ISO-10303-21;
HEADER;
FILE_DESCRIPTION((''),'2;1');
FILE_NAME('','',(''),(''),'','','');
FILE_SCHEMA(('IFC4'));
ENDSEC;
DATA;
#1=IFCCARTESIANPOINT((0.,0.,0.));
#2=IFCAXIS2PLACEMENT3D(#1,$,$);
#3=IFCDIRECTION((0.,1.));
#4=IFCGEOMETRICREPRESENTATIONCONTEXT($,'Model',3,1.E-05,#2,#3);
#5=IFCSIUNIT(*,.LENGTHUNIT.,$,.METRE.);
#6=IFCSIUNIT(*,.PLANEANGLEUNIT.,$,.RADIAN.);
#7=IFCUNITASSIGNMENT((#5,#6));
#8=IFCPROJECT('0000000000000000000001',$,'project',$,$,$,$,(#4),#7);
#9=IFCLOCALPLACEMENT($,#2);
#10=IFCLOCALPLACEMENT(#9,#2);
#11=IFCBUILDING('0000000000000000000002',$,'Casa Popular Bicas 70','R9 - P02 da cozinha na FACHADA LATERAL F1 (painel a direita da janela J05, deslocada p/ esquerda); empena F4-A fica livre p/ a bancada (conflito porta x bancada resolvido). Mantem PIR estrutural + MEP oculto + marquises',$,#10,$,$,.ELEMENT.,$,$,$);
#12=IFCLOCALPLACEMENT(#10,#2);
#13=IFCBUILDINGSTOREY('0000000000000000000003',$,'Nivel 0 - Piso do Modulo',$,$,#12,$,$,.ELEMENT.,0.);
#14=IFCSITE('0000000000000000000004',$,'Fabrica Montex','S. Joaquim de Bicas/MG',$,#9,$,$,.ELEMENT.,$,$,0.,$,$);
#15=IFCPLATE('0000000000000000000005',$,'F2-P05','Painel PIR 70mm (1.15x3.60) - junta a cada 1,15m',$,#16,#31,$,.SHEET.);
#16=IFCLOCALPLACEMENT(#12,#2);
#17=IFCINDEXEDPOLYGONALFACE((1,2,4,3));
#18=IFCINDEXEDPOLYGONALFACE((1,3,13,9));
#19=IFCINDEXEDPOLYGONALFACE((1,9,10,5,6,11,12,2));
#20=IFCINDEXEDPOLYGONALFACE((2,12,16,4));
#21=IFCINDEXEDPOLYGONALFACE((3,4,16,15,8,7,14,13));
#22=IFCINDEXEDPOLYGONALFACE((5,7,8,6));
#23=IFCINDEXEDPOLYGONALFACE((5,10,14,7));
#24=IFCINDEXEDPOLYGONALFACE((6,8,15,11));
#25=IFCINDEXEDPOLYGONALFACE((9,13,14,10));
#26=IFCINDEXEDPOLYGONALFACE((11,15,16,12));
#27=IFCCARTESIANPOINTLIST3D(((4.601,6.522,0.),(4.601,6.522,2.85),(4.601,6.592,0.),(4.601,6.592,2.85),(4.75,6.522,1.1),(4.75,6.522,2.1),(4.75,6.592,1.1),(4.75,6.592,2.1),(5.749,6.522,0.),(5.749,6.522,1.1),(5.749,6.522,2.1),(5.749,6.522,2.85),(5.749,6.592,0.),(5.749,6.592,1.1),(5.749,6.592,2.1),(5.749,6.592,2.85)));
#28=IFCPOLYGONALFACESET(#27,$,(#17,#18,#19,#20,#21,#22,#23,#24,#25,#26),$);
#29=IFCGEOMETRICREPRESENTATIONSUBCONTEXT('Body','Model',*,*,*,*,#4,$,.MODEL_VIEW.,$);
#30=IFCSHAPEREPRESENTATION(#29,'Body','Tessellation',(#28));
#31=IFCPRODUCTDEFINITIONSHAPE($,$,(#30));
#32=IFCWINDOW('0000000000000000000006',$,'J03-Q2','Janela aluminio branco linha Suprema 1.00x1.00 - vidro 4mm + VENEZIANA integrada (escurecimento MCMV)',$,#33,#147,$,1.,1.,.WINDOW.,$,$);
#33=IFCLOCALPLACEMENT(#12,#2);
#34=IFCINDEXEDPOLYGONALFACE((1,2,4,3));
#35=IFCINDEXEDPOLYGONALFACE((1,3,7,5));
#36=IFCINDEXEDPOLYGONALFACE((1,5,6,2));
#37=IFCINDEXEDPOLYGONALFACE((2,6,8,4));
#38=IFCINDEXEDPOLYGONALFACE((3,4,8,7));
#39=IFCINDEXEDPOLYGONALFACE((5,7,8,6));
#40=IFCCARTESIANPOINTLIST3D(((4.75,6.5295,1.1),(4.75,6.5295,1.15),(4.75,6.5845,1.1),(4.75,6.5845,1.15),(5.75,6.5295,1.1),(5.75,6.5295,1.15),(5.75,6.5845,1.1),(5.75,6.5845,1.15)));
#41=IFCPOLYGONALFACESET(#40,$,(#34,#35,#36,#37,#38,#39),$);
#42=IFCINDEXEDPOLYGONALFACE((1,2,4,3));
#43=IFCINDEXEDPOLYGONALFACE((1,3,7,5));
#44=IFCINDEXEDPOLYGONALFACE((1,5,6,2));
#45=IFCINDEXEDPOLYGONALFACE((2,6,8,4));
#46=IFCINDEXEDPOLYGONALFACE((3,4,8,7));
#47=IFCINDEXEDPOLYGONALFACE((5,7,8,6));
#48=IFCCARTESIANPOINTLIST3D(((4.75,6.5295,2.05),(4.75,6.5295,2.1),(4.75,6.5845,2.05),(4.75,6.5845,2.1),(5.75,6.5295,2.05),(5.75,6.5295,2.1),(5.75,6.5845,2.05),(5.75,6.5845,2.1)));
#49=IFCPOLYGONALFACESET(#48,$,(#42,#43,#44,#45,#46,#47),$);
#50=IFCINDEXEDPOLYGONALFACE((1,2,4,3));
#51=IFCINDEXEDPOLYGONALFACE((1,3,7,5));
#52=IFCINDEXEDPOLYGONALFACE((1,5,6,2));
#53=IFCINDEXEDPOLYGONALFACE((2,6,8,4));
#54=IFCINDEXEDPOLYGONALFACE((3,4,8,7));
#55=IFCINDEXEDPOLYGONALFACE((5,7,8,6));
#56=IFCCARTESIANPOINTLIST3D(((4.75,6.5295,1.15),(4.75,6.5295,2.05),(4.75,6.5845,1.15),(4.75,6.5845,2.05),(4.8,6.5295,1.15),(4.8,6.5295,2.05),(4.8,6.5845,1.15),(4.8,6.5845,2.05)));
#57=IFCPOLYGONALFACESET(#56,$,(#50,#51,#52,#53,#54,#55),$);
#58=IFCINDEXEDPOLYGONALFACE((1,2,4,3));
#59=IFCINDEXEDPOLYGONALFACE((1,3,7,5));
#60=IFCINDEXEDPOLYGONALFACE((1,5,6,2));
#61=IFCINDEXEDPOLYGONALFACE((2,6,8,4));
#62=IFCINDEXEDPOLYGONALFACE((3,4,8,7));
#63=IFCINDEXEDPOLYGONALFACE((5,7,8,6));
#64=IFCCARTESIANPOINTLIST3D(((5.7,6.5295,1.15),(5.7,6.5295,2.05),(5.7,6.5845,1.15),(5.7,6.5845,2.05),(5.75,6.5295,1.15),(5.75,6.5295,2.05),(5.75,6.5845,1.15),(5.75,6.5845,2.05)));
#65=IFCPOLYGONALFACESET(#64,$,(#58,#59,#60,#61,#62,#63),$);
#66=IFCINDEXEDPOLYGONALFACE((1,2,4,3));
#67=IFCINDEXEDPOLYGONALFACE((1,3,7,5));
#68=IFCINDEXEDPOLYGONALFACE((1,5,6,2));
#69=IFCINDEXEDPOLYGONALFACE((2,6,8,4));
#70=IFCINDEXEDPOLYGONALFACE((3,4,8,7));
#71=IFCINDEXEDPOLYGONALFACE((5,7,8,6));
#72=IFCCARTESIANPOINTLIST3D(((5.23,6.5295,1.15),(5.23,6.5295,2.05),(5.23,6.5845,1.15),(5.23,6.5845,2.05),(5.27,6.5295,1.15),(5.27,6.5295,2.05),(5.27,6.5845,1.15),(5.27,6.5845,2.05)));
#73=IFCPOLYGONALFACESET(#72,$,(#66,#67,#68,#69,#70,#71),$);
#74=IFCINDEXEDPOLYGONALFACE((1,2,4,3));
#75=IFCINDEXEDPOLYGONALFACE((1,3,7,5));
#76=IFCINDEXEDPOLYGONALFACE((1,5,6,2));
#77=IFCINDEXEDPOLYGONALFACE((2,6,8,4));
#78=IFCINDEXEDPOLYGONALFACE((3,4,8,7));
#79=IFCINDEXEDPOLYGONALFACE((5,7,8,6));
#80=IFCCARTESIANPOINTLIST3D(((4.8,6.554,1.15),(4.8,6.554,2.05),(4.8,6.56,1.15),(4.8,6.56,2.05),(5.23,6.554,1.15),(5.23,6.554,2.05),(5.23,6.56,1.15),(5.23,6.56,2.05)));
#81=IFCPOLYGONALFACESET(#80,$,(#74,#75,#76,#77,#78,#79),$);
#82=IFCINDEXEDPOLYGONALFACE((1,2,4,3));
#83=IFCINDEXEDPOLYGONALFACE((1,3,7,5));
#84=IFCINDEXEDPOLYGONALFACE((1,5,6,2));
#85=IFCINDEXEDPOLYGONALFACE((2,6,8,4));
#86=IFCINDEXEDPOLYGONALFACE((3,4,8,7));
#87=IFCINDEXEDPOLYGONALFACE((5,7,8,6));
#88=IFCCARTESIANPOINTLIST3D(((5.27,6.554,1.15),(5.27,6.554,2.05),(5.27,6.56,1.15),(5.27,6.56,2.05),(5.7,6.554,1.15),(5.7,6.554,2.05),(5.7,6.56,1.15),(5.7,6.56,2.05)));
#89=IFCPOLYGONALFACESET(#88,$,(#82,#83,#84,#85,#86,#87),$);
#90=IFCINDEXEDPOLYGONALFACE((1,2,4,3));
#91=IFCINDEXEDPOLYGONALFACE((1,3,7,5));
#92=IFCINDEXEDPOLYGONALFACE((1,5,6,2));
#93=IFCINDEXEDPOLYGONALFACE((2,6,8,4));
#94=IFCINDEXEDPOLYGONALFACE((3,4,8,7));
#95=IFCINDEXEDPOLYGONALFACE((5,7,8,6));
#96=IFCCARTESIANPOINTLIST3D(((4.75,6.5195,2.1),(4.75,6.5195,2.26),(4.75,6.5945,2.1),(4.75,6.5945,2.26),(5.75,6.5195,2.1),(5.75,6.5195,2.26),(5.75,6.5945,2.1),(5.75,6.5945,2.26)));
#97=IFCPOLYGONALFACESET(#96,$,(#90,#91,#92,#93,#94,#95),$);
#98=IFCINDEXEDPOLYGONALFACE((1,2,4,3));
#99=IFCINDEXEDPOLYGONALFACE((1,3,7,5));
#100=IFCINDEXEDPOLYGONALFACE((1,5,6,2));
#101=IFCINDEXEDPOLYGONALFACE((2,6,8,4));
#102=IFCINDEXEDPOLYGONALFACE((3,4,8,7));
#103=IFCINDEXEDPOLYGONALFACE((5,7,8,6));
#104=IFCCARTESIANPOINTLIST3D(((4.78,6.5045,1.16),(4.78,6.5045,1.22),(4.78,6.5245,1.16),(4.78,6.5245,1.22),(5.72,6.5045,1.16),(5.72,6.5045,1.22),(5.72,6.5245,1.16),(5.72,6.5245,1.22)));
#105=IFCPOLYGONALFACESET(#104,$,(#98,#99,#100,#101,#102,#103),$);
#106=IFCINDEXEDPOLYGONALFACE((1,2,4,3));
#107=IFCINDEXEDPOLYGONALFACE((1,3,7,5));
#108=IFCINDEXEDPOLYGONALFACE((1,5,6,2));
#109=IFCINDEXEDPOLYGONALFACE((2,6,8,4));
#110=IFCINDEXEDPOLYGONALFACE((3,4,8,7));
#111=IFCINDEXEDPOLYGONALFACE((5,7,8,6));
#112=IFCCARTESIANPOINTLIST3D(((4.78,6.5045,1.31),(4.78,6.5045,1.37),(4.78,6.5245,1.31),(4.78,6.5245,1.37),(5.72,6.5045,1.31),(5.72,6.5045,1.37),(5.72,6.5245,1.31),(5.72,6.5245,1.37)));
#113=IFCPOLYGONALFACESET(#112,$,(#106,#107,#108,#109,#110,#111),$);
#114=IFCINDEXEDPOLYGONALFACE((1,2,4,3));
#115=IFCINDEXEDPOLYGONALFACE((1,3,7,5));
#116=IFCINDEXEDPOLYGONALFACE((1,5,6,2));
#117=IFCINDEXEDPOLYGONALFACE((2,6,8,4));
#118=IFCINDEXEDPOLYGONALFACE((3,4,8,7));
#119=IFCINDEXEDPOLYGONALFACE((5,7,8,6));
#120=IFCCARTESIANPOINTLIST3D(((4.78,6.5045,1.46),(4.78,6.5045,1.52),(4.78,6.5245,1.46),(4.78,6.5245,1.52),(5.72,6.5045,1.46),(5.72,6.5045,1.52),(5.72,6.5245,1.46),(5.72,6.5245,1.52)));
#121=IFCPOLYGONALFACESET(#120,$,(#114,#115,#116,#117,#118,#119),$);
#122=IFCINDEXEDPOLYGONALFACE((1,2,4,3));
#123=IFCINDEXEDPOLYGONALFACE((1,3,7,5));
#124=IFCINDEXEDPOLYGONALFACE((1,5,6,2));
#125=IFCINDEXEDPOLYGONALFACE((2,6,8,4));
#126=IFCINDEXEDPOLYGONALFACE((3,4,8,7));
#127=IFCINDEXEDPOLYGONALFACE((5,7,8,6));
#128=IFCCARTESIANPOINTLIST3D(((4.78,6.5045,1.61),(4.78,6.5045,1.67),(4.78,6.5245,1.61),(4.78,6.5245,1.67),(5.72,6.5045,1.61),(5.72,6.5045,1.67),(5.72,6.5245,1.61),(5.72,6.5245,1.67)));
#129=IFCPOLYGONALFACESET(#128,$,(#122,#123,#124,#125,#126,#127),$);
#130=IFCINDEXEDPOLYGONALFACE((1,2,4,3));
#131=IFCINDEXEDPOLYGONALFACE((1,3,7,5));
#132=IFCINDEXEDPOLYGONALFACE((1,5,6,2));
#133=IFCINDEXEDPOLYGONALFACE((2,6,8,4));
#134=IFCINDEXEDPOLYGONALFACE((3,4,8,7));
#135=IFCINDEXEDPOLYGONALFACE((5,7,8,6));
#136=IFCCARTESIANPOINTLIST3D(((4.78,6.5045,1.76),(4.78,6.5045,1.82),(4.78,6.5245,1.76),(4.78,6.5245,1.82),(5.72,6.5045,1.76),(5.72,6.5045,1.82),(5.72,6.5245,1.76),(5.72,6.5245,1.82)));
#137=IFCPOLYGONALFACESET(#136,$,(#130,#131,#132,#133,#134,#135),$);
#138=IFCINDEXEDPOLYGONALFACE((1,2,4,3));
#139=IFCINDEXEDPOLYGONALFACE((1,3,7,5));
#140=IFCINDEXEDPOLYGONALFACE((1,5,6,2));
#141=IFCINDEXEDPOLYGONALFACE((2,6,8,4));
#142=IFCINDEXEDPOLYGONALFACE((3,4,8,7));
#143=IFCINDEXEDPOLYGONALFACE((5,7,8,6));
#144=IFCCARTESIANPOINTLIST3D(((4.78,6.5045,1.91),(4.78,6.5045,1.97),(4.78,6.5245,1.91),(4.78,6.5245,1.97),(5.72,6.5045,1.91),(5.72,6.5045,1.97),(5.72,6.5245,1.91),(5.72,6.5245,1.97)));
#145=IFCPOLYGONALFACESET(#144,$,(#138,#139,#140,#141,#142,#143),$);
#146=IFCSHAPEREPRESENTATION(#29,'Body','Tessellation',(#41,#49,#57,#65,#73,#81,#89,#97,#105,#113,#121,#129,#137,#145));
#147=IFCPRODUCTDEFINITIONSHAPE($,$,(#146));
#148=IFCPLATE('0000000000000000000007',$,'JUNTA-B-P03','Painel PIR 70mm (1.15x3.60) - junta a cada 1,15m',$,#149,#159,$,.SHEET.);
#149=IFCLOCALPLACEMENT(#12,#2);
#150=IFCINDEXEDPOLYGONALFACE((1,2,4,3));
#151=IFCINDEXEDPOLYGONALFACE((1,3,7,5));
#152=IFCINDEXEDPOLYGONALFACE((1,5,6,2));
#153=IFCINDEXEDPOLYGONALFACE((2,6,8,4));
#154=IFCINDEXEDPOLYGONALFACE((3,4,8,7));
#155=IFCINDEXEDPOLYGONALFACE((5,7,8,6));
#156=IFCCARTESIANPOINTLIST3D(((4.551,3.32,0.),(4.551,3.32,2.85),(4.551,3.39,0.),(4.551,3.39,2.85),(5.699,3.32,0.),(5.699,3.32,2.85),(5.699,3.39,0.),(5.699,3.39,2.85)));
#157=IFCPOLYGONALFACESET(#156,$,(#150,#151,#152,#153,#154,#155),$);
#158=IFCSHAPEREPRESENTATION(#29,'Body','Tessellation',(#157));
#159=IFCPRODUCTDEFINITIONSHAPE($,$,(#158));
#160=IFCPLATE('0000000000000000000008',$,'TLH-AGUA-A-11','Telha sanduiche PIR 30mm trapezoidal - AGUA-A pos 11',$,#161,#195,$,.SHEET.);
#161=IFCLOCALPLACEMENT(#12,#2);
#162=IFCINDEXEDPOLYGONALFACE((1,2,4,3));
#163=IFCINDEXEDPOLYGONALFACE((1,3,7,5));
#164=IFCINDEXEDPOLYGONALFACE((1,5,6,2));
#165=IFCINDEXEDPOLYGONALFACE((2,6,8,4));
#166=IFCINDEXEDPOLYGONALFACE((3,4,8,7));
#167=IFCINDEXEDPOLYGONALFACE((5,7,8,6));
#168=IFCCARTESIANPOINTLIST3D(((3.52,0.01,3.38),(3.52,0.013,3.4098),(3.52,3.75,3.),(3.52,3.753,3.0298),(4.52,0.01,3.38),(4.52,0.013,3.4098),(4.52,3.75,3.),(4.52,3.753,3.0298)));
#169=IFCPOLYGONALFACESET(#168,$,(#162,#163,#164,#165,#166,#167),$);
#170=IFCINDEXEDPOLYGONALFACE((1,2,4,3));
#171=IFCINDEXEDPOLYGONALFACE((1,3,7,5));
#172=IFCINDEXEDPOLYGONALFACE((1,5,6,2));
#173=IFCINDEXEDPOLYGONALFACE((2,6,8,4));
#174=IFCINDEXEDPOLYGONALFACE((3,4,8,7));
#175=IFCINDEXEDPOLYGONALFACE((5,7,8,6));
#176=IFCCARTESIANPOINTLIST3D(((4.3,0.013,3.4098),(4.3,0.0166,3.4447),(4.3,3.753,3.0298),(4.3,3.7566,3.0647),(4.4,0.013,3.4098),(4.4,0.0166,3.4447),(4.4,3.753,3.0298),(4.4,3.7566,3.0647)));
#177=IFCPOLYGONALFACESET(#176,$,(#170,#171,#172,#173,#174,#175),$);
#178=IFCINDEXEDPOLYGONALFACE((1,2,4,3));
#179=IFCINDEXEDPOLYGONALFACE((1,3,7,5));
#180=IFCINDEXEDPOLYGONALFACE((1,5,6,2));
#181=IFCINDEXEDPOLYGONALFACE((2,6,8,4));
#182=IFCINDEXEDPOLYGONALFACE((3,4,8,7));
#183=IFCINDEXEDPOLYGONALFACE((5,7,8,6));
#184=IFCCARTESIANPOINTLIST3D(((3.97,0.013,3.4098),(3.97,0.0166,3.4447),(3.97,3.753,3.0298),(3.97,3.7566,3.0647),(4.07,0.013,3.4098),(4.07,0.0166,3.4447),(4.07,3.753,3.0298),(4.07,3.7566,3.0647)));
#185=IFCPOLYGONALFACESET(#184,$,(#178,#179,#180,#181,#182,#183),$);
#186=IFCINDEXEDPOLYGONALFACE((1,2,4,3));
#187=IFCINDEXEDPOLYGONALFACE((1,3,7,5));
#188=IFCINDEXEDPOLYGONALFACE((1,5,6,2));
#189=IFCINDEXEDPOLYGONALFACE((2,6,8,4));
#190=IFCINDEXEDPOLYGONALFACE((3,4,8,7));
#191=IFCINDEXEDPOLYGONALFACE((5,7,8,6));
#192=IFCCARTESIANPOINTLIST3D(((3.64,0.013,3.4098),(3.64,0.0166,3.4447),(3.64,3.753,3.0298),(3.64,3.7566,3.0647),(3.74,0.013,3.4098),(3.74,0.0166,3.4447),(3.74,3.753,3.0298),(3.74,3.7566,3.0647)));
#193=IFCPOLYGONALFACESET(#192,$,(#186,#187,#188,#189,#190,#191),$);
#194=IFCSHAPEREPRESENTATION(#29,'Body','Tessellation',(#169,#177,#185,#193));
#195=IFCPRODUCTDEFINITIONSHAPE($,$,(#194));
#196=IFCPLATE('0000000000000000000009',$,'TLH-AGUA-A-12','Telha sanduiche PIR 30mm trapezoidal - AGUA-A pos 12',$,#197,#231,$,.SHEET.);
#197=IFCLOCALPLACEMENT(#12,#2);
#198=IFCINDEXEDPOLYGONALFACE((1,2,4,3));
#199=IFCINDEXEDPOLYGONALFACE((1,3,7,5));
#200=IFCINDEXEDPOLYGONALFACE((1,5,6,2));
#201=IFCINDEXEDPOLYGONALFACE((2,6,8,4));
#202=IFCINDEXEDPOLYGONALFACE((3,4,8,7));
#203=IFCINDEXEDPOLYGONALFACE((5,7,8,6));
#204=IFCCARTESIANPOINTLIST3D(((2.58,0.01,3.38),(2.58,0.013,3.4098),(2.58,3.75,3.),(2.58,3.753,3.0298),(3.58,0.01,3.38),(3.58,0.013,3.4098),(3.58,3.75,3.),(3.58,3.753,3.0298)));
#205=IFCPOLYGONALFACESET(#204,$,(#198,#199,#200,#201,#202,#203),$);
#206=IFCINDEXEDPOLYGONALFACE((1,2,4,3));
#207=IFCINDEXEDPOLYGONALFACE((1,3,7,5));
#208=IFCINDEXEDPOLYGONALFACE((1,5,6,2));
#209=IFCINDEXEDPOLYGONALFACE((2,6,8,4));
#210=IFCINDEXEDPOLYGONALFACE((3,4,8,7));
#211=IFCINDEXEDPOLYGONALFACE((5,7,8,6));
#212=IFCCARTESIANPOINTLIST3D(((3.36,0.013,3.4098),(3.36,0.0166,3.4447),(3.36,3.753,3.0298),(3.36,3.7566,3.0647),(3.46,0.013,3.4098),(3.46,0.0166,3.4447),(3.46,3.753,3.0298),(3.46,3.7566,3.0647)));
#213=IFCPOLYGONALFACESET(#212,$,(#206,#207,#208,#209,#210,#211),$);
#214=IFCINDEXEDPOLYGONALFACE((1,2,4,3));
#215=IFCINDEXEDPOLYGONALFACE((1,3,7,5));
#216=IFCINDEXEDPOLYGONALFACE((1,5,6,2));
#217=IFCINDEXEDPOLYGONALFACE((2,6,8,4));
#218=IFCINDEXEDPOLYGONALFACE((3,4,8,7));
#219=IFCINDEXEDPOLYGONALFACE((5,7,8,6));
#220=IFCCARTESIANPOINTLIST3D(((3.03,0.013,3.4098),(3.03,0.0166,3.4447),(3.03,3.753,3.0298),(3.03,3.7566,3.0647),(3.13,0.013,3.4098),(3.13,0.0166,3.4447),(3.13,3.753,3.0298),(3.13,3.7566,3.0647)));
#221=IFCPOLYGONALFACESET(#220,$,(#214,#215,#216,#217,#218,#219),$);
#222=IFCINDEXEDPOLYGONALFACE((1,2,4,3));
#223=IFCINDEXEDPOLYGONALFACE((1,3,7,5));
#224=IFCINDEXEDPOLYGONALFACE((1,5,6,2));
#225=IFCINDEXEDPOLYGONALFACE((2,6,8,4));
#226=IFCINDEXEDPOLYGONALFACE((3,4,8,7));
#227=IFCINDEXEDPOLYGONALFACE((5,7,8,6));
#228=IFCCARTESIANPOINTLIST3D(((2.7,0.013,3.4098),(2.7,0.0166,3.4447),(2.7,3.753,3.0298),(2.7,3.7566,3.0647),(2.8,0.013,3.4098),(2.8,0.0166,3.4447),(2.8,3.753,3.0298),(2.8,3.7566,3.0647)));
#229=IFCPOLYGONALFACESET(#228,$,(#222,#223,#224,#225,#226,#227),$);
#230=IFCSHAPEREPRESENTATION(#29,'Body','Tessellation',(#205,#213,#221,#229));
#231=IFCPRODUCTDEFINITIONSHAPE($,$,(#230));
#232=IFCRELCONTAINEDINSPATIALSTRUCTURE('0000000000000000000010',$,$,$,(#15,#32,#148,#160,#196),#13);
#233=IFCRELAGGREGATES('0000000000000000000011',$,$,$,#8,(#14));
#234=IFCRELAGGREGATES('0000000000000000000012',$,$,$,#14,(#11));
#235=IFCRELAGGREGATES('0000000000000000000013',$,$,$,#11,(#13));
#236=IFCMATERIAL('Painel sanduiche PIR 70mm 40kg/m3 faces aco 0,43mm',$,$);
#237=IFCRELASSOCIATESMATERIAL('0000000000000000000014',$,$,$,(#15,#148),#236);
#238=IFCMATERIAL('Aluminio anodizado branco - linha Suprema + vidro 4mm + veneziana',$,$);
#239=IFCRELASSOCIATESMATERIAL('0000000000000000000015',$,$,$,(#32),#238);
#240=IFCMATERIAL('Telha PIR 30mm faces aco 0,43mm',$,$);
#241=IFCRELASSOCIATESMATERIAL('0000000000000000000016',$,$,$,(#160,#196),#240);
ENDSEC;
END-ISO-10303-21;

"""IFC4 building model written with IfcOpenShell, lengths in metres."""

from ifc_helpers import new_model, si_unit, direction, frame, frame_2d, origin, origin_2d, place, context, subcontext, project, spatial, rectangle, extrude, material, element, fill, save


model = new_model("IFC4")

# Units and contexts
model_context = context("Model", 3, precision=1e-05, world=origin(), true_north=direction((0.0, 1.0)))
body_context = subcontext(model_context, "Body", "Model", "MODEL_VIEW")
ifc_project = project(units=[si_unit("LENGTHUNIT", "METRE"), si_unit("PLANEANGLEUNIT", "RADIAN")], contexts=[model_context])

# Site, building, storey
site_placement = place(None, origin())
site = spatial("IfcSite", under=ifc_project, at=site_placement, Name="Fabrica Montex", Description="S. Joaquim de Bicas/MG", CompositionType="ELEMENT", RefElevation=0.0)
building_placement = place(site_placement, origin())
building = spatial("IfcBuilding", under=site, at=building_placement, Name="Casa Popular Bicas 70", Description="R9 - P02 da cozinha na FACHADA LATERAL F1 (painel a direita da janela J05, deslocada p/ esquerda); empena F4-A fica livre p/ a bancada (conflito porta x bancada resolvido). Mantem PIR estrutural + MEP oculto + marquises", CompositionType="ELEMENT")
storey_placement = place(building_placement, origin())
storey = spatial("IfcBuildingStorey", under=building, at=storey_placement, Name="Nivel 0 - Piso do Modulo", CompositionType="ELEMENT", Elevation=0.0)

# Shared definitions
ifc_material_1 = material(Name="Painel sanduiche PIR 70mm 40kg/m3 faces aco 0,43mm")

# Plate, opening, window
plate_1_placement = place(storey_placement, frame((4.601, 6.557, 0.0), x_axis=(1.0, 0.0, 0.0)))
plate_1 = element("IfcPlate", 1, at=plate_1_placement, inside=storey, material=ifc_material_1, Name="F2-P05", Description="Painel PIR 70mm (1.15x3.60) - junta a cada 1,15m", PredefinedType="SHEET", context=body_context, shape_type="SweptSolid", body=[
    extrude(rectangle(XDim=1.148, YDim=0.07, at=frame_2d((0.574, 0.0))), origin(), (0.0, 0.0, 1.0), 2.85),
])
opening_1_placement = place(storey_placement, frame((5.25, 6.557, 1.1)))
opening_1 = element("IfcOpeningElement", 2, at=opening_1_placement, cuts=plate_1, PredefinedType="OPENING", context=body_context, shape_type="SweptSolid", body=[
    extrude(rectangle(XDim=1.0, YDim=0.1, at=origin_2d()), origin(), (0.0, 0.0, 1.0), 1.0),
])
ifc_material_2 = material(Name="Aluminio anodizado branco - linha Suprema + vidro 4mm + veneziana")
window_placement = place(storey_placement, frame((4.75, 6.557, 1.1), x_axis=(1.0, 0.0, 0.0)))
window = element("IfcWindow", 3, at=window_placement, inside=storey, material=ifc_material_2, Name="J03-Q2", Description="Janela aluminio branco linha Suprema 1.00x1.00 - vidro 4mm + VENEZIANA integrada (escurecimento MCMV)", OverallHeight=1.0, OverallWidth=1.0, PredefinedType="WINDOW", context=body_context, shape_type="SweptSolid", body=[
    extrude(rectangle(XDim=1.0, YDim=0.055, at=frame_2d((0.5, 0.0))), origin(), (0.0, 0.0, 1.0), 0.05),
    extrude(rectangle(XDim=1.0, YDim=0.055, at=frame_2d((0.5, 0.0))), frame((0.0, 0.0, 0.95)), (0.0, 0.0, 1.0), 0.05),
    extrude(rectangle(XDim=0.05, YDim=0.055, at=frame_2d((0.025, 0.0))), frame((0.0, 0.0, 0.05)), (0.0, 0.0, 1.0), 0.9),
    extrude(rectangle(XDim=0.05, YDim=0.055, at=frame_2d((0.975, 0.0))), frame((0.0, 0.0, 0.05)), (0.0, 0.0, 1.0), 0.9),
    extrude(rectangle(XDim=0.04, YDim=0.055, at=frame_2d((0.5, 0.0))), frame((0.0, 0.0, 0.05)), (0.0, 0.0, 1.0), 0.9),
    extrude(rectangle(XDim=0.43, YDim=0.006, at=frame_2d((0.265, 0.0))), frame((0.0, 0.0, 0.05)), (0.0, 0.0, 1.0), 0.9),
    extrude(rectangle(XDim=0.43, YDim=0.006, at=frame_2d((0.735, 0.0))), frame((0.0, 0.0, 0.05)), (0.0, 0.0, 1.0), 0.9),
    extrude(rectangle(XDim=1.0, YDim=0.075, at=frame_2d((0.5, 0.0))), frame((0.0, 0.0, 1.0)), (0.0, 0.0, 1.0), 0.16),
    extrude(rectangle(XDim=0.94, YDim=0.02, at=frame_2d((0.5, -0.0425))), frame((0.0, 0.0, 0.06)), (0.0, 0.0, 1.0), 0.06),
    extrude(rectangle(XDim=0.94, YDim=0.02, at=frame_2d((0.5, -0.0425))), frame((0.0, 0.0, 0.21)), (0.0, 0.0, 1.0), 0.06),
    extrude(rectangle(XDim=0.94, YDim=0.02, at=frame_2d((0.5, -0.0425))), frame((0.0, 0.0, 0.36)), (0.0, 0.0, 1.0), 0.06),
    extrude(rectangle(XDim=0.94, YDim=0.02, at=frame_2d((0.5, -0.0425))), frame((0.0, 0.0, 0.51)), (0.0, 0.0, 1.0), 0.06),
    extrude(rectangle(XDim=0.94, YDim=0.02, at=frame_2d((0.5, -0.0425))), frame((0.0, 0.0, 0.66)), (0.0, 0.0, 1.0), 0.06),
    extrude(rectangle(XDim=0.94, YDim=0.02, at=frame_2d((0.5, -0.0425))), frame((0.0, 0.0, 0.81)), (0.0, 0.0, 1.0), 0.06),
])
fill(opening_1, window)

# Plates
plate_2_placement = place(storey_placement, frame((4.551, 3.355, 0.0), x_axis=(1.0, 0.0, 0.0)))
element("IfcPlate", 4, at=plate_2_placement, inside=storey, material=ifc_material_1, Name="JUNTA-B-P03", Description="Painel PIR 70mm (1.15x3.60) - junta a cada 1,15m", PredefinedType="SHEET", context=body_context, shape_type="SweptSolid", body=[
    extrude(rectangle(XDim=1.148, YDim=0.07, at=frame_2d((0.574, 0.0))), origin(), (0.0, 0.0, 1.0), 2.85),
])
ifc_material_3 = material(Name="Telha PIR 30mm faces aco 0,43mm")
for number, where, z_axis, x_axis, name, description in (
    (5, (4.52, 3.75, 3.0), (0.0, 0.101084, 0.994878), (-1.0, 0.0, 0.0), "TLH-AGUA-A-11", "Telha sanduiche PIR 30mm trapezoidal - AGUA-A pos 11"),
    (6, (3.58, 3.75, 3.0), (0.0, 0.101084, 0.994878), (-1.0, 0.0, 0.0), "TLH-AGUA-A-12", "Telha sanduiche PIR 30mm trapezoidal - AGUA-A pos 12"),
):
    element("IfcPlate", number, at=place(None, frame(where, z_axis=z_axis, x_axis=x_axis)), inside=storey, material=ifc_material_3, Name=name, Description=description, PredefinedType="SHEET", context=body_context, shape_type="SweptSolid", body=[
        extrude(rectangle(XDim=1.0, YDim=3.7593, at=frame_2d((0.5, 1.8796))), origin(), (0.0, 0.0, 1.0), 0.03),
        extrude(rectangle(XDim=0.1, YDim=3.7593, at=frame_2d((0.17, 1.8796))), frame((0.0, 0.0, 0.03)), (0.0, 0.0, 1.0), 0.035),
        extrude(rectangle(XDim=0.1, YDim=3.7593, at=frame_2d((0.5, 1.8796))), frame((0.0, 0.0, 0.03)), (0.0, 0.0, 1.0), 0.035),
        extrude(rectangle(XDim=0.1, YDim=3.7593, at=frame_2d((0.83, 1.8796))), frame((0.0, 0.0, 0.03)), (0.0, 0.0, 1.0), 0.035),
    ])

save(model, "model.ifc")
